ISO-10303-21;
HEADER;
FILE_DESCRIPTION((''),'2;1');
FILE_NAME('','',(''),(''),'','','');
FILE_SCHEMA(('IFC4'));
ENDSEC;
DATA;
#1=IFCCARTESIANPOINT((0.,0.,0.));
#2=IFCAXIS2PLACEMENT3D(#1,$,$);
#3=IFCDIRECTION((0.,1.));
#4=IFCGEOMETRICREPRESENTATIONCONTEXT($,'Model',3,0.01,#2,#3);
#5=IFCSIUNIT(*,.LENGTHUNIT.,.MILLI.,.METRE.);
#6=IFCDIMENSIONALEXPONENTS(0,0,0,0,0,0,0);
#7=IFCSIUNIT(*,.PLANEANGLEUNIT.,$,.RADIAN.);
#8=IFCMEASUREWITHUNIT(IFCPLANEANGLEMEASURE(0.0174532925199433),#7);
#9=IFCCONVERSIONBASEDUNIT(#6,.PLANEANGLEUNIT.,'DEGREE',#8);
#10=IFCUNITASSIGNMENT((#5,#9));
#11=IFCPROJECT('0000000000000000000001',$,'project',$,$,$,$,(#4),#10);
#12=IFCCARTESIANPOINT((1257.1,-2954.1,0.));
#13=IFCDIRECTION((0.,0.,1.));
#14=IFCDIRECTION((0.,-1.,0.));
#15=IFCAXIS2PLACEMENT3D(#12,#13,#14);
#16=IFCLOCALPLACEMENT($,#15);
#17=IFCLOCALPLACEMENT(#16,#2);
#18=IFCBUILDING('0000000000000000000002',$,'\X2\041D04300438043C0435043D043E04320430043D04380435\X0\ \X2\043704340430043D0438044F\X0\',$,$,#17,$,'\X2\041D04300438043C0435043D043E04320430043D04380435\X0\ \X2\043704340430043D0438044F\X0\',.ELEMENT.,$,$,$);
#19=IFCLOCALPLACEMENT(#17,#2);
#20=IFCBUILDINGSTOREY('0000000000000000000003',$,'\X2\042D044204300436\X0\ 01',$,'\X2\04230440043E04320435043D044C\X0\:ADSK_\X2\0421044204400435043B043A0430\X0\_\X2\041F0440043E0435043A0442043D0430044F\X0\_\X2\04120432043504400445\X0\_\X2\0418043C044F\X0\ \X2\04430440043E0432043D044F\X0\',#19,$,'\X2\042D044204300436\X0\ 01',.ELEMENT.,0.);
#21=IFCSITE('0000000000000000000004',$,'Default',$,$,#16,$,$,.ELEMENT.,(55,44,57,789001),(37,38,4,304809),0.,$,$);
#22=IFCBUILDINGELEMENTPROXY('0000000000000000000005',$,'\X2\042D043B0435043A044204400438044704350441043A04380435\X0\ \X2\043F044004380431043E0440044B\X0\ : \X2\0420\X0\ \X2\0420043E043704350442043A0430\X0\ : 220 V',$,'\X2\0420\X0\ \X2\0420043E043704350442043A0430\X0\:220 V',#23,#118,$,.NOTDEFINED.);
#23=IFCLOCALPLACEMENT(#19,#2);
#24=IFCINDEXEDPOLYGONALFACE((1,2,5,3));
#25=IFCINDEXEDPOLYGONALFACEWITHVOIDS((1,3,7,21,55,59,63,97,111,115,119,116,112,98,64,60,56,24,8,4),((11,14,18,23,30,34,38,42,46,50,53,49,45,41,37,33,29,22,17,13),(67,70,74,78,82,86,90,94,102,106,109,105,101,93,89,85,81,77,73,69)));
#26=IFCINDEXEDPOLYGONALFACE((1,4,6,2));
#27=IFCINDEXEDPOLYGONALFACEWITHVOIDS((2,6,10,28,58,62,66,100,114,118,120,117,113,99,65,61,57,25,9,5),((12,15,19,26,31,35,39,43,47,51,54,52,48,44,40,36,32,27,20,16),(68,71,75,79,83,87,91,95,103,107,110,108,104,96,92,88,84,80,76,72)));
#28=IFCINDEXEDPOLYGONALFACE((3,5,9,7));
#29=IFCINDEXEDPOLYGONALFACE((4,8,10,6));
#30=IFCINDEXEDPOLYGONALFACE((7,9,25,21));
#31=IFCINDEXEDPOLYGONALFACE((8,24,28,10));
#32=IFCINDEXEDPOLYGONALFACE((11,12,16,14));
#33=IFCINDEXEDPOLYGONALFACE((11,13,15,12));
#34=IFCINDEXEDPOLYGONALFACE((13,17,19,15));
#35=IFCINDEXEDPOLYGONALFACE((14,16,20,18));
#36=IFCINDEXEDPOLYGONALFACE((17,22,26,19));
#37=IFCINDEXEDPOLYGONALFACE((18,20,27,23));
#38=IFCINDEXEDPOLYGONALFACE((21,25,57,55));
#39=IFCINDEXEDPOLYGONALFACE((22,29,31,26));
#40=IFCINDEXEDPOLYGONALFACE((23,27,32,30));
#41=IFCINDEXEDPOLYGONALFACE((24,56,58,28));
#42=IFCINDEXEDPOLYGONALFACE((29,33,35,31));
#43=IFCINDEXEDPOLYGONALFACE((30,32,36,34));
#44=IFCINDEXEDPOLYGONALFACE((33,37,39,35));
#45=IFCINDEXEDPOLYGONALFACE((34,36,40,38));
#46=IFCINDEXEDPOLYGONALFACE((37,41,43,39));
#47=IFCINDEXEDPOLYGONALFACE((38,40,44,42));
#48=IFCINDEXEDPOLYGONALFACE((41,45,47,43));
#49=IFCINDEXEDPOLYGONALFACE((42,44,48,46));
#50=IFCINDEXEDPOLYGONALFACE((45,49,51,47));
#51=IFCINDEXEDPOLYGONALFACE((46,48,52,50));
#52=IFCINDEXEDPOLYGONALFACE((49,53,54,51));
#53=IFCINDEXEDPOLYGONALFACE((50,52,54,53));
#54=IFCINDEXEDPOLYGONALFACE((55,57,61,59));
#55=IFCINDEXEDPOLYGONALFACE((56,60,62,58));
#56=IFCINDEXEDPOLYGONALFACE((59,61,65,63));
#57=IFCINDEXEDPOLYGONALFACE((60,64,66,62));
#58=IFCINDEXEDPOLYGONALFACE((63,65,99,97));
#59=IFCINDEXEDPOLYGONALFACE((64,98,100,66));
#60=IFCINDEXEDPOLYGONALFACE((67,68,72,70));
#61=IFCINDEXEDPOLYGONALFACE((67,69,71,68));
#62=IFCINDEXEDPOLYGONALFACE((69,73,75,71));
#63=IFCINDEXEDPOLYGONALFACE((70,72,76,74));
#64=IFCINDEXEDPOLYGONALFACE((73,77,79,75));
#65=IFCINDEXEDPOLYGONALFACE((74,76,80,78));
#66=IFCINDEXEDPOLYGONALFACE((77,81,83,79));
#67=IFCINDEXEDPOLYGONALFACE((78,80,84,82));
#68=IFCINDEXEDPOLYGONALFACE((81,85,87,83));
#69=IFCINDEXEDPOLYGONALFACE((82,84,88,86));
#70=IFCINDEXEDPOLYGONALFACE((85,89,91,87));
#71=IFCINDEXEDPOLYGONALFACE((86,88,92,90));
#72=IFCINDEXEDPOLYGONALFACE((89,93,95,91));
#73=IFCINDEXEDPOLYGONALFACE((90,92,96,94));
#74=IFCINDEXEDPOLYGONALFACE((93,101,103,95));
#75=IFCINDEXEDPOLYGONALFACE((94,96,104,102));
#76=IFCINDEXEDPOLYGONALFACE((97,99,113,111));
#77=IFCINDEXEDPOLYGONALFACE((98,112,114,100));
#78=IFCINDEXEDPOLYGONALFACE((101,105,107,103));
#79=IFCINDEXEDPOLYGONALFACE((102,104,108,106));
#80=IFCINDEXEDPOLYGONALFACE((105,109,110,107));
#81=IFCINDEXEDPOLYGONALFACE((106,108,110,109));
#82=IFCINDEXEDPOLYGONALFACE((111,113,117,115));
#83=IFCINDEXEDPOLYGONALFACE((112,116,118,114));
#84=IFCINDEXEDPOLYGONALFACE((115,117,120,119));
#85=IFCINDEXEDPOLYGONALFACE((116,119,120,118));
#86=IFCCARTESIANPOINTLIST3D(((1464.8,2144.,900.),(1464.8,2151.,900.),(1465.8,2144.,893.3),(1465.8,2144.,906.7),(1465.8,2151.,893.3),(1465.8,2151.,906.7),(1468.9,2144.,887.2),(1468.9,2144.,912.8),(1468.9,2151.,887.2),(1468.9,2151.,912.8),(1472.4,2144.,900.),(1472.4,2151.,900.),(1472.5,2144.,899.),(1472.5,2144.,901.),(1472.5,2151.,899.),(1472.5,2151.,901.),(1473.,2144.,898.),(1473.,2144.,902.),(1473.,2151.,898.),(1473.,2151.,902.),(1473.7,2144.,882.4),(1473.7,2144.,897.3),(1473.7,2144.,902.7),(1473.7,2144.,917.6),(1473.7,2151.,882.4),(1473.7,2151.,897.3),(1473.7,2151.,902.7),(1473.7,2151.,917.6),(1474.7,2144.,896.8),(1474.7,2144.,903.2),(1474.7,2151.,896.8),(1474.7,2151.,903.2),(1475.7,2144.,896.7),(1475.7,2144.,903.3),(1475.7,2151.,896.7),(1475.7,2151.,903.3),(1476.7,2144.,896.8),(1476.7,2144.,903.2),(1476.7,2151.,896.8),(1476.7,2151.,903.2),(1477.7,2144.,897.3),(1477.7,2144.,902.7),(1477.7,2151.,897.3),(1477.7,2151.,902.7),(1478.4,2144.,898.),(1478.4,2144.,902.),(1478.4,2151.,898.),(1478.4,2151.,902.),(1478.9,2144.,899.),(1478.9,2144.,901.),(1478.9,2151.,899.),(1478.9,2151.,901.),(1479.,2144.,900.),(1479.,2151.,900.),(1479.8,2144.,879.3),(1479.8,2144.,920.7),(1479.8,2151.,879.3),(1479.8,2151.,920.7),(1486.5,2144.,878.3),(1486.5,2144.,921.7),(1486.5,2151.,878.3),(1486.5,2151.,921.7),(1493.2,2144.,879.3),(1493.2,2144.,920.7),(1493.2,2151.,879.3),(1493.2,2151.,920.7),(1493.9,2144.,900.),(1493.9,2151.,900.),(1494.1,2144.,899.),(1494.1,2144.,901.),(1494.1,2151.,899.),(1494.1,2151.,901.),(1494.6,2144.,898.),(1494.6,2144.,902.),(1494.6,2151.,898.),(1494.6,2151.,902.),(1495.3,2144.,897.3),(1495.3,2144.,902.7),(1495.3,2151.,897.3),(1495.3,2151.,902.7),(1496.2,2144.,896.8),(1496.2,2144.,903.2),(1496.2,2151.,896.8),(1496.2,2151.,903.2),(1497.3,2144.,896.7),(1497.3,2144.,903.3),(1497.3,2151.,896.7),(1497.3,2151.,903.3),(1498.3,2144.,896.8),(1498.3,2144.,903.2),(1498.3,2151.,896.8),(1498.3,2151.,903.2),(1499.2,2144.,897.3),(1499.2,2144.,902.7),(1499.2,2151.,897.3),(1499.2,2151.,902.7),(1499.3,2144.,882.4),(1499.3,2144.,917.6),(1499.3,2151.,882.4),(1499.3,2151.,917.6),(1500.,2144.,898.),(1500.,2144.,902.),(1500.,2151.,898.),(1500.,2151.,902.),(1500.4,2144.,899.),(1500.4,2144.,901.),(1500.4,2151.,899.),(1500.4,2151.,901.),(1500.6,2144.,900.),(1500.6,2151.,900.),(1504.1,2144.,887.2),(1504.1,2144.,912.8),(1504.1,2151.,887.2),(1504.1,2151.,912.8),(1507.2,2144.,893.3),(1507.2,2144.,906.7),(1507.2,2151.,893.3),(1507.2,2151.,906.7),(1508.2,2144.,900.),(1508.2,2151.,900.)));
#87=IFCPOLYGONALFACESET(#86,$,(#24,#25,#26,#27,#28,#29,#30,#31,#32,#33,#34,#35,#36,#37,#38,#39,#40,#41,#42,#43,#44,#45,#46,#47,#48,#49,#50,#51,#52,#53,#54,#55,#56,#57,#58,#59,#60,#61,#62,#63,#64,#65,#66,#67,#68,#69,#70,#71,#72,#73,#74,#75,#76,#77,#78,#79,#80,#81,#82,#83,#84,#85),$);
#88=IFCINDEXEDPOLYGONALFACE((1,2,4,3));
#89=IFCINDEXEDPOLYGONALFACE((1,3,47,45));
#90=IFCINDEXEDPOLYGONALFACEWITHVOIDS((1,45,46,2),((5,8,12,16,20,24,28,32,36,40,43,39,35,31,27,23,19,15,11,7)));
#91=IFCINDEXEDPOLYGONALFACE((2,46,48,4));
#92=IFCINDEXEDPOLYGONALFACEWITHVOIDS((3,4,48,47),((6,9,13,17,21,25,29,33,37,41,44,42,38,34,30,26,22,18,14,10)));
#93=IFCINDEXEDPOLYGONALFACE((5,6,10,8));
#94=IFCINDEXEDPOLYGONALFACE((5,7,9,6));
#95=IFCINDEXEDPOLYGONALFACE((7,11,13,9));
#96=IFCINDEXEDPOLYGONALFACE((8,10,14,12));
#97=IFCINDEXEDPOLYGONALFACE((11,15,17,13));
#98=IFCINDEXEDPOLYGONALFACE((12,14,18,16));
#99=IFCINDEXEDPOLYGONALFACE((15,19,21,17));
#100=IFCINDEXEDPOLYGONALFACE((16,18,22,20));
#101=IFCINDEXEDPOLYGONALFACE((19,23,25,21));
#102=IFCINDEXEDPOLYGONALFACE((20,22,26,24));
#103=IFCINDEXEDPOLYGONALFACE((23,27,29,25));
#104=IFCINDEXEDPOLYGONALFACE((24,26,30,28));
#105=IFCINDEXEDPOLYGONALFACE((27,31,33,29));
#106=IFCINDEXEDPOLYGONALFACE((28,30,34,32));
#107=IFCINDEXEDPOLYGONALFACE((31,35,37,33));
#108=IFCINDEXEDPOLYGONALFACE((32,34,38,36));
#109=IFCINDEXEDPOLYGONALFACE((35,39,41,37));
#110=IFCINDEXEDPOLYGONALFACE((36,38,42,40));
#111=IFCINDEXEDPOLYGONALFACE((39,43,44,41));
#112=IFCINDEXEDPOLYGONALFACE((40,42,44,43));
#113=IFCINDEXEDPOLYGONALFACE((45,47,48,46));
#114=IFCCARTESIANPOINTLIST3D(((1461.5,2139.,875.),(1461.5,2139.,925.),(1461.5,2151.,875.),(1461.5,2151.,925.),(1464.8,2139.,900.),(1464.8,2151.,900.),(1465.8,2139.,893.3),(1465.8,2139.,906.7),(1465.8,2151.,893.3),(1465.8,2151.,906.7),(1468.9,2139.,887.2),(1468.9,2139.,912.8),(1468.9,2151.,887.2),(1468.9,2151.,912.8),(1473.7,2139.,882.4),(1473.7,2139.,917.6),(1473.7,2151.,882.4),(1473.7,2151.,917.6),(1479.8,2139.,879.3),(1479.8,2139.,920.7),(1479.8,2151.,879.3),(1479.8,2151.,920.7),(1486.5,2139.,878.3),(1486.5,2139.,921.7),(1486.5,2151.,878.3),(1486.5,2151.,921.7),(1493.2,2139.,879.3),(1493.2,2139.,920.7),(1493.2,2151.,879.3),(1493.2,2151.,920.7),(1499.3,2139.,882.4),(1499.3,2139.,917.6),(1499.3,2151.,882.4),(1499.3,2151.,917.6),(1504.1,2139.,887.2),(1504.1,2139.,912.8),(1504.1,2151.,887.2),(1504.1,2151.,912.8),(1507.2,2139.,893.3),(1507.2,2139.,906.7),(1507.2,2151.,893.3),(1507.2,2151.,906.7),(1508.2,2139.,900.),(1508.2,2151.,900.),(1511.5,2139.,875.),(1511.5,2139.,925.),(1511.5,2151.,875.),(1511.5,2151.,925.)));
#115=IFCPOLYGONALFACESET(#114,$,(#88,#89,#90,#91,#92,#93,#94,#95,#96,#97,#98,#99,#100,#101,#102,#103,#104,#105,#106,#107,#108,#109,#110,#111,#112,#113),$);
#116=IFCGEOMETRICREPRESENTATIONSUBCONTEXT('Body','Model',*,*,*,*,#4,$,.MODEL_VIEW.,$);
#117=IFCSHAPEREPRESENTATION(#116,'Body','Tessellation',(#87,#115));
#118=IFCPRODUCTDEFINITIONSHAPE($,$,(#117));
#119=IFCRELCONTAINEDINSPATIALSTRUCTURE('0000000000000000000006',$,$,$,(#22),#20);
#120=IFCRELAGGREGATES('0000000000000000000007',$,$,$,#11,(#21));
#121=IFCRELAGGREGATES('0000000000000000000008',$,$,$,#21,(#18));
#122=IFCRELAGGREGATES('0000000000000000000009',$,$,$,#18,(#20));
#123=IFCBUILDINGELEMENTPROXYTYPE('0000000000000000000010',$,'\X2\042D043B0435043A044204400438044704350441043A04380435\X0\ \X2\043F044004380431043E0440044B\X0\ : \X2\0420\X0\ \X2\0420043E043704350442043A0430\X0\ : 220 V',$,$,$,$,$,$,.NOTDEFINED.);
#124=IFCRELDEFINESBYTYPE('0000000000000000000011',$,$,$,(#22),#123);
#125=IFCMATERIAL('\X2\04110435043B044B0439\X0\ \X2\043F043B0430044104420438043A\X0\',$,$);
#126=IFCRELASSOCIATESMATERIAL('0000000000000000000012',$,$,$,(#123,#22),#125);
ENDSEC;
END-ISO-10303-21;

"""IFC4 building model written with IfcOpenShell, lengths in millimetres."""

from ifc_helpers import new_model, entity, si_unit, converted_unit, direction, frame, origin, place, context, subcontext, project, spatial, indexed_curve, outline, extrude, source, transform, mapped, material, type_object, type_shapes, element, save


model = new_model("IFC4")

# Units and contexts
model_context = context("Model", 3, precision=0.01, world=origin(), true_north=direction((0.0, 1.0)))
body_context = subcontext(model_context, "Body", "Model", "MODEL_VIEW")
ifc_project = project(units=[si_unit("LENGTHUNIT", "METRE", prefix="MILLI"), converted_unit("PLANEANGLEUNIT", "DEGREE", entity("IfcPlaneAngleMeasure", 0.0174532925199433), si_unit("PLANEANGLEUNIT", "RADIAN"), dimensions=[0, 0, 0, 0, 0, 0, 0])], contexts=[model_context])

# Site, building, storey
site_placement = place(None, frame((1257.1, -2954.1, 0.0), z_axis=(0.0, 0.0, 1.0), x_axis=(0.0, -1.0, 0.0)))
site = spatial("IfcSite", under=ifc_project, at=site_placement, Name="Default", CompositionType="ELEMENT", RefLatitude=(55, 44, 57, 789001), RefLongitude=(37, 38, 4, 304809), RefElevation=0.0)
building_placement = place(site_placement, origin())
building = spatial("IfcBuilding", under=site, at=building_placement, Name="Наименование здания", LongName="Наименование здания", CompositionType="ELEMENT")
storey_placement = place(building_placement, origin())
storey = spatial("IfcBuildingStorey", under=building, at=storey_placement, Name="Этаж 01", ObjectType="Уровень:ADSK_Стрелка_Проектная_Вверх_Имя уровня", LongName="Этаж 01", CompositionType="ELEMENT", Elevation=0.0)

# Building element proxy
ifc_material_1 = material(Name="Белый пластик")
building_element_proxy_type_1 = type_object("IfcBuildingElementProxyType", Name="Электрические приборы : Р Розетка : 220 V", PredefinedType="NOTDEFINED", material=ifc_material_1)
shared_shape_1 = source(origin(), body_context, "Body", "SweptSolid", [
    extrude(outline(indexed_curve([(21.7, 0.0), (20.7, 6.7), (17.6, 12.8), (12.8, 17.6), (6.7, 20.7), (0.0, 21.7), (-6.7, 20.7), (-12.8, 17.6), (-17.6, 12.8), (-20.7, 6.7), (-21.7, 0.0), (-20.7, -6.7), (-17.6, -12.8), (-12.8, -17.6), (-6.7, -20.7), (0.0, -21.7), (6.7, -20.7), (12.8, -17.6), (17.6, -12.8), (20.7, -6.7), (21.7, 0.0)], self_intersect=False), holes=[indexed_curve([(-7.5, 0.0), (-7.6, -1.0), (-8.1, -2.0), (-8.8, -2.7), (-9.8, -3.2), (-10.8, -3.3), (-11.8, -3.2), (-12.8, -2.7), (-13.5, -2.0), (-14.0, -1.0), (-14.1, 0.0), (-14.0, 1.0), (-13.5, 2.0), (-12.8, 2.7), (-11.8, 3.2), (-10.8, 3.3), (-9.8, 3.2), (-8.8, 2.7), (-8.1, 2.0), (-7.6, 1.0), (-7.5, 0.0)], self_intersect=False), indexed_curve([(14.1, 0.0), (13.9, -1.0), (13.5, -2.0), (12.7, -2.7), (11.8, -3.2), (10.8, -3.3), (9.7, -3.2), (8.8, -2.7), (8.1, -2.0), (7.6, -1.0), (7.4, 0.0), (7.6, 1.0), (8.1, 2.0), (8.8, 2.7), (9.7, 3.2), (10.8, 3.3), (11.8, 3.2), (12.7, 2.7), (13.5, 2.0), (13.9, 1.0), (14.1, 0.0)], self_intersect=False)]), frame((345.3, -712.5, 0.0)), (0.0, 0.0, 1.0), 7.0),
    extrude(outline(indexed_curve([(-25.0, -25.0), (25.0, -25.0), (25.0, 25.0), (-25.0, 25.0), (-25.0, -25.0)], self_intersect=False), holes=[indexed_curve([(-21.7, 0.0), (-20.7, 6.7), (-17.6, 12.8), (-12.8, 17.6), (-6.7, 20.7), (0.0, 21.7), (6.7, 20.7), (12.8, 17.6), (17.6, 12.8), (20.7, 6.7), (21.7, 0.0), (20.7, -6.7), (17.6, -12.8), (12.8, -17.6), (6.7, -20.7), (0.0, -21.7), (-6.7, -20.7), (-12.8, -17.6), (-17.6, -12.8), (-20.7, -6.7), (-21.7, 0.0)], self_intersect=False)]), frame((345.3, -712.5, 0.0), z_axis=(0.0, 0.0, 1.0), x_axis=(-1.0, 0.0, 0.0)), (0.0, 0.0, 1.0), 12.0),
])
type_shapes(building_element_proxy_type_1, [shared_shape_1])
for number, where, z_axis, x_axis, name in (
    (1, (1141.2, 2151.0, 1612.5), (0.0, -1.0, 0.0), (1.0, 0.0, 0.0), "Электрические приборы : Р Розетка : 220 V"),
):
    element("IfcBuildingElementProxy", number, at=place(storey_placement, frame(where, z_axis=z_axis, x_axis=x_axis)), inside=storey, type_object=building_element_proxy_type_1, material=ifc_material_1, Name=name, ObjectType="Р Розетка:220 V", PredefinedType="NOTDEFINED", context=body_context, shape_type="MappedRepresentation", body=[
        mapped(shared_shape_1, transform((0.0, 0.0, 0.0), scale=1.0)),
    ])

save(model, "model.ifc")
